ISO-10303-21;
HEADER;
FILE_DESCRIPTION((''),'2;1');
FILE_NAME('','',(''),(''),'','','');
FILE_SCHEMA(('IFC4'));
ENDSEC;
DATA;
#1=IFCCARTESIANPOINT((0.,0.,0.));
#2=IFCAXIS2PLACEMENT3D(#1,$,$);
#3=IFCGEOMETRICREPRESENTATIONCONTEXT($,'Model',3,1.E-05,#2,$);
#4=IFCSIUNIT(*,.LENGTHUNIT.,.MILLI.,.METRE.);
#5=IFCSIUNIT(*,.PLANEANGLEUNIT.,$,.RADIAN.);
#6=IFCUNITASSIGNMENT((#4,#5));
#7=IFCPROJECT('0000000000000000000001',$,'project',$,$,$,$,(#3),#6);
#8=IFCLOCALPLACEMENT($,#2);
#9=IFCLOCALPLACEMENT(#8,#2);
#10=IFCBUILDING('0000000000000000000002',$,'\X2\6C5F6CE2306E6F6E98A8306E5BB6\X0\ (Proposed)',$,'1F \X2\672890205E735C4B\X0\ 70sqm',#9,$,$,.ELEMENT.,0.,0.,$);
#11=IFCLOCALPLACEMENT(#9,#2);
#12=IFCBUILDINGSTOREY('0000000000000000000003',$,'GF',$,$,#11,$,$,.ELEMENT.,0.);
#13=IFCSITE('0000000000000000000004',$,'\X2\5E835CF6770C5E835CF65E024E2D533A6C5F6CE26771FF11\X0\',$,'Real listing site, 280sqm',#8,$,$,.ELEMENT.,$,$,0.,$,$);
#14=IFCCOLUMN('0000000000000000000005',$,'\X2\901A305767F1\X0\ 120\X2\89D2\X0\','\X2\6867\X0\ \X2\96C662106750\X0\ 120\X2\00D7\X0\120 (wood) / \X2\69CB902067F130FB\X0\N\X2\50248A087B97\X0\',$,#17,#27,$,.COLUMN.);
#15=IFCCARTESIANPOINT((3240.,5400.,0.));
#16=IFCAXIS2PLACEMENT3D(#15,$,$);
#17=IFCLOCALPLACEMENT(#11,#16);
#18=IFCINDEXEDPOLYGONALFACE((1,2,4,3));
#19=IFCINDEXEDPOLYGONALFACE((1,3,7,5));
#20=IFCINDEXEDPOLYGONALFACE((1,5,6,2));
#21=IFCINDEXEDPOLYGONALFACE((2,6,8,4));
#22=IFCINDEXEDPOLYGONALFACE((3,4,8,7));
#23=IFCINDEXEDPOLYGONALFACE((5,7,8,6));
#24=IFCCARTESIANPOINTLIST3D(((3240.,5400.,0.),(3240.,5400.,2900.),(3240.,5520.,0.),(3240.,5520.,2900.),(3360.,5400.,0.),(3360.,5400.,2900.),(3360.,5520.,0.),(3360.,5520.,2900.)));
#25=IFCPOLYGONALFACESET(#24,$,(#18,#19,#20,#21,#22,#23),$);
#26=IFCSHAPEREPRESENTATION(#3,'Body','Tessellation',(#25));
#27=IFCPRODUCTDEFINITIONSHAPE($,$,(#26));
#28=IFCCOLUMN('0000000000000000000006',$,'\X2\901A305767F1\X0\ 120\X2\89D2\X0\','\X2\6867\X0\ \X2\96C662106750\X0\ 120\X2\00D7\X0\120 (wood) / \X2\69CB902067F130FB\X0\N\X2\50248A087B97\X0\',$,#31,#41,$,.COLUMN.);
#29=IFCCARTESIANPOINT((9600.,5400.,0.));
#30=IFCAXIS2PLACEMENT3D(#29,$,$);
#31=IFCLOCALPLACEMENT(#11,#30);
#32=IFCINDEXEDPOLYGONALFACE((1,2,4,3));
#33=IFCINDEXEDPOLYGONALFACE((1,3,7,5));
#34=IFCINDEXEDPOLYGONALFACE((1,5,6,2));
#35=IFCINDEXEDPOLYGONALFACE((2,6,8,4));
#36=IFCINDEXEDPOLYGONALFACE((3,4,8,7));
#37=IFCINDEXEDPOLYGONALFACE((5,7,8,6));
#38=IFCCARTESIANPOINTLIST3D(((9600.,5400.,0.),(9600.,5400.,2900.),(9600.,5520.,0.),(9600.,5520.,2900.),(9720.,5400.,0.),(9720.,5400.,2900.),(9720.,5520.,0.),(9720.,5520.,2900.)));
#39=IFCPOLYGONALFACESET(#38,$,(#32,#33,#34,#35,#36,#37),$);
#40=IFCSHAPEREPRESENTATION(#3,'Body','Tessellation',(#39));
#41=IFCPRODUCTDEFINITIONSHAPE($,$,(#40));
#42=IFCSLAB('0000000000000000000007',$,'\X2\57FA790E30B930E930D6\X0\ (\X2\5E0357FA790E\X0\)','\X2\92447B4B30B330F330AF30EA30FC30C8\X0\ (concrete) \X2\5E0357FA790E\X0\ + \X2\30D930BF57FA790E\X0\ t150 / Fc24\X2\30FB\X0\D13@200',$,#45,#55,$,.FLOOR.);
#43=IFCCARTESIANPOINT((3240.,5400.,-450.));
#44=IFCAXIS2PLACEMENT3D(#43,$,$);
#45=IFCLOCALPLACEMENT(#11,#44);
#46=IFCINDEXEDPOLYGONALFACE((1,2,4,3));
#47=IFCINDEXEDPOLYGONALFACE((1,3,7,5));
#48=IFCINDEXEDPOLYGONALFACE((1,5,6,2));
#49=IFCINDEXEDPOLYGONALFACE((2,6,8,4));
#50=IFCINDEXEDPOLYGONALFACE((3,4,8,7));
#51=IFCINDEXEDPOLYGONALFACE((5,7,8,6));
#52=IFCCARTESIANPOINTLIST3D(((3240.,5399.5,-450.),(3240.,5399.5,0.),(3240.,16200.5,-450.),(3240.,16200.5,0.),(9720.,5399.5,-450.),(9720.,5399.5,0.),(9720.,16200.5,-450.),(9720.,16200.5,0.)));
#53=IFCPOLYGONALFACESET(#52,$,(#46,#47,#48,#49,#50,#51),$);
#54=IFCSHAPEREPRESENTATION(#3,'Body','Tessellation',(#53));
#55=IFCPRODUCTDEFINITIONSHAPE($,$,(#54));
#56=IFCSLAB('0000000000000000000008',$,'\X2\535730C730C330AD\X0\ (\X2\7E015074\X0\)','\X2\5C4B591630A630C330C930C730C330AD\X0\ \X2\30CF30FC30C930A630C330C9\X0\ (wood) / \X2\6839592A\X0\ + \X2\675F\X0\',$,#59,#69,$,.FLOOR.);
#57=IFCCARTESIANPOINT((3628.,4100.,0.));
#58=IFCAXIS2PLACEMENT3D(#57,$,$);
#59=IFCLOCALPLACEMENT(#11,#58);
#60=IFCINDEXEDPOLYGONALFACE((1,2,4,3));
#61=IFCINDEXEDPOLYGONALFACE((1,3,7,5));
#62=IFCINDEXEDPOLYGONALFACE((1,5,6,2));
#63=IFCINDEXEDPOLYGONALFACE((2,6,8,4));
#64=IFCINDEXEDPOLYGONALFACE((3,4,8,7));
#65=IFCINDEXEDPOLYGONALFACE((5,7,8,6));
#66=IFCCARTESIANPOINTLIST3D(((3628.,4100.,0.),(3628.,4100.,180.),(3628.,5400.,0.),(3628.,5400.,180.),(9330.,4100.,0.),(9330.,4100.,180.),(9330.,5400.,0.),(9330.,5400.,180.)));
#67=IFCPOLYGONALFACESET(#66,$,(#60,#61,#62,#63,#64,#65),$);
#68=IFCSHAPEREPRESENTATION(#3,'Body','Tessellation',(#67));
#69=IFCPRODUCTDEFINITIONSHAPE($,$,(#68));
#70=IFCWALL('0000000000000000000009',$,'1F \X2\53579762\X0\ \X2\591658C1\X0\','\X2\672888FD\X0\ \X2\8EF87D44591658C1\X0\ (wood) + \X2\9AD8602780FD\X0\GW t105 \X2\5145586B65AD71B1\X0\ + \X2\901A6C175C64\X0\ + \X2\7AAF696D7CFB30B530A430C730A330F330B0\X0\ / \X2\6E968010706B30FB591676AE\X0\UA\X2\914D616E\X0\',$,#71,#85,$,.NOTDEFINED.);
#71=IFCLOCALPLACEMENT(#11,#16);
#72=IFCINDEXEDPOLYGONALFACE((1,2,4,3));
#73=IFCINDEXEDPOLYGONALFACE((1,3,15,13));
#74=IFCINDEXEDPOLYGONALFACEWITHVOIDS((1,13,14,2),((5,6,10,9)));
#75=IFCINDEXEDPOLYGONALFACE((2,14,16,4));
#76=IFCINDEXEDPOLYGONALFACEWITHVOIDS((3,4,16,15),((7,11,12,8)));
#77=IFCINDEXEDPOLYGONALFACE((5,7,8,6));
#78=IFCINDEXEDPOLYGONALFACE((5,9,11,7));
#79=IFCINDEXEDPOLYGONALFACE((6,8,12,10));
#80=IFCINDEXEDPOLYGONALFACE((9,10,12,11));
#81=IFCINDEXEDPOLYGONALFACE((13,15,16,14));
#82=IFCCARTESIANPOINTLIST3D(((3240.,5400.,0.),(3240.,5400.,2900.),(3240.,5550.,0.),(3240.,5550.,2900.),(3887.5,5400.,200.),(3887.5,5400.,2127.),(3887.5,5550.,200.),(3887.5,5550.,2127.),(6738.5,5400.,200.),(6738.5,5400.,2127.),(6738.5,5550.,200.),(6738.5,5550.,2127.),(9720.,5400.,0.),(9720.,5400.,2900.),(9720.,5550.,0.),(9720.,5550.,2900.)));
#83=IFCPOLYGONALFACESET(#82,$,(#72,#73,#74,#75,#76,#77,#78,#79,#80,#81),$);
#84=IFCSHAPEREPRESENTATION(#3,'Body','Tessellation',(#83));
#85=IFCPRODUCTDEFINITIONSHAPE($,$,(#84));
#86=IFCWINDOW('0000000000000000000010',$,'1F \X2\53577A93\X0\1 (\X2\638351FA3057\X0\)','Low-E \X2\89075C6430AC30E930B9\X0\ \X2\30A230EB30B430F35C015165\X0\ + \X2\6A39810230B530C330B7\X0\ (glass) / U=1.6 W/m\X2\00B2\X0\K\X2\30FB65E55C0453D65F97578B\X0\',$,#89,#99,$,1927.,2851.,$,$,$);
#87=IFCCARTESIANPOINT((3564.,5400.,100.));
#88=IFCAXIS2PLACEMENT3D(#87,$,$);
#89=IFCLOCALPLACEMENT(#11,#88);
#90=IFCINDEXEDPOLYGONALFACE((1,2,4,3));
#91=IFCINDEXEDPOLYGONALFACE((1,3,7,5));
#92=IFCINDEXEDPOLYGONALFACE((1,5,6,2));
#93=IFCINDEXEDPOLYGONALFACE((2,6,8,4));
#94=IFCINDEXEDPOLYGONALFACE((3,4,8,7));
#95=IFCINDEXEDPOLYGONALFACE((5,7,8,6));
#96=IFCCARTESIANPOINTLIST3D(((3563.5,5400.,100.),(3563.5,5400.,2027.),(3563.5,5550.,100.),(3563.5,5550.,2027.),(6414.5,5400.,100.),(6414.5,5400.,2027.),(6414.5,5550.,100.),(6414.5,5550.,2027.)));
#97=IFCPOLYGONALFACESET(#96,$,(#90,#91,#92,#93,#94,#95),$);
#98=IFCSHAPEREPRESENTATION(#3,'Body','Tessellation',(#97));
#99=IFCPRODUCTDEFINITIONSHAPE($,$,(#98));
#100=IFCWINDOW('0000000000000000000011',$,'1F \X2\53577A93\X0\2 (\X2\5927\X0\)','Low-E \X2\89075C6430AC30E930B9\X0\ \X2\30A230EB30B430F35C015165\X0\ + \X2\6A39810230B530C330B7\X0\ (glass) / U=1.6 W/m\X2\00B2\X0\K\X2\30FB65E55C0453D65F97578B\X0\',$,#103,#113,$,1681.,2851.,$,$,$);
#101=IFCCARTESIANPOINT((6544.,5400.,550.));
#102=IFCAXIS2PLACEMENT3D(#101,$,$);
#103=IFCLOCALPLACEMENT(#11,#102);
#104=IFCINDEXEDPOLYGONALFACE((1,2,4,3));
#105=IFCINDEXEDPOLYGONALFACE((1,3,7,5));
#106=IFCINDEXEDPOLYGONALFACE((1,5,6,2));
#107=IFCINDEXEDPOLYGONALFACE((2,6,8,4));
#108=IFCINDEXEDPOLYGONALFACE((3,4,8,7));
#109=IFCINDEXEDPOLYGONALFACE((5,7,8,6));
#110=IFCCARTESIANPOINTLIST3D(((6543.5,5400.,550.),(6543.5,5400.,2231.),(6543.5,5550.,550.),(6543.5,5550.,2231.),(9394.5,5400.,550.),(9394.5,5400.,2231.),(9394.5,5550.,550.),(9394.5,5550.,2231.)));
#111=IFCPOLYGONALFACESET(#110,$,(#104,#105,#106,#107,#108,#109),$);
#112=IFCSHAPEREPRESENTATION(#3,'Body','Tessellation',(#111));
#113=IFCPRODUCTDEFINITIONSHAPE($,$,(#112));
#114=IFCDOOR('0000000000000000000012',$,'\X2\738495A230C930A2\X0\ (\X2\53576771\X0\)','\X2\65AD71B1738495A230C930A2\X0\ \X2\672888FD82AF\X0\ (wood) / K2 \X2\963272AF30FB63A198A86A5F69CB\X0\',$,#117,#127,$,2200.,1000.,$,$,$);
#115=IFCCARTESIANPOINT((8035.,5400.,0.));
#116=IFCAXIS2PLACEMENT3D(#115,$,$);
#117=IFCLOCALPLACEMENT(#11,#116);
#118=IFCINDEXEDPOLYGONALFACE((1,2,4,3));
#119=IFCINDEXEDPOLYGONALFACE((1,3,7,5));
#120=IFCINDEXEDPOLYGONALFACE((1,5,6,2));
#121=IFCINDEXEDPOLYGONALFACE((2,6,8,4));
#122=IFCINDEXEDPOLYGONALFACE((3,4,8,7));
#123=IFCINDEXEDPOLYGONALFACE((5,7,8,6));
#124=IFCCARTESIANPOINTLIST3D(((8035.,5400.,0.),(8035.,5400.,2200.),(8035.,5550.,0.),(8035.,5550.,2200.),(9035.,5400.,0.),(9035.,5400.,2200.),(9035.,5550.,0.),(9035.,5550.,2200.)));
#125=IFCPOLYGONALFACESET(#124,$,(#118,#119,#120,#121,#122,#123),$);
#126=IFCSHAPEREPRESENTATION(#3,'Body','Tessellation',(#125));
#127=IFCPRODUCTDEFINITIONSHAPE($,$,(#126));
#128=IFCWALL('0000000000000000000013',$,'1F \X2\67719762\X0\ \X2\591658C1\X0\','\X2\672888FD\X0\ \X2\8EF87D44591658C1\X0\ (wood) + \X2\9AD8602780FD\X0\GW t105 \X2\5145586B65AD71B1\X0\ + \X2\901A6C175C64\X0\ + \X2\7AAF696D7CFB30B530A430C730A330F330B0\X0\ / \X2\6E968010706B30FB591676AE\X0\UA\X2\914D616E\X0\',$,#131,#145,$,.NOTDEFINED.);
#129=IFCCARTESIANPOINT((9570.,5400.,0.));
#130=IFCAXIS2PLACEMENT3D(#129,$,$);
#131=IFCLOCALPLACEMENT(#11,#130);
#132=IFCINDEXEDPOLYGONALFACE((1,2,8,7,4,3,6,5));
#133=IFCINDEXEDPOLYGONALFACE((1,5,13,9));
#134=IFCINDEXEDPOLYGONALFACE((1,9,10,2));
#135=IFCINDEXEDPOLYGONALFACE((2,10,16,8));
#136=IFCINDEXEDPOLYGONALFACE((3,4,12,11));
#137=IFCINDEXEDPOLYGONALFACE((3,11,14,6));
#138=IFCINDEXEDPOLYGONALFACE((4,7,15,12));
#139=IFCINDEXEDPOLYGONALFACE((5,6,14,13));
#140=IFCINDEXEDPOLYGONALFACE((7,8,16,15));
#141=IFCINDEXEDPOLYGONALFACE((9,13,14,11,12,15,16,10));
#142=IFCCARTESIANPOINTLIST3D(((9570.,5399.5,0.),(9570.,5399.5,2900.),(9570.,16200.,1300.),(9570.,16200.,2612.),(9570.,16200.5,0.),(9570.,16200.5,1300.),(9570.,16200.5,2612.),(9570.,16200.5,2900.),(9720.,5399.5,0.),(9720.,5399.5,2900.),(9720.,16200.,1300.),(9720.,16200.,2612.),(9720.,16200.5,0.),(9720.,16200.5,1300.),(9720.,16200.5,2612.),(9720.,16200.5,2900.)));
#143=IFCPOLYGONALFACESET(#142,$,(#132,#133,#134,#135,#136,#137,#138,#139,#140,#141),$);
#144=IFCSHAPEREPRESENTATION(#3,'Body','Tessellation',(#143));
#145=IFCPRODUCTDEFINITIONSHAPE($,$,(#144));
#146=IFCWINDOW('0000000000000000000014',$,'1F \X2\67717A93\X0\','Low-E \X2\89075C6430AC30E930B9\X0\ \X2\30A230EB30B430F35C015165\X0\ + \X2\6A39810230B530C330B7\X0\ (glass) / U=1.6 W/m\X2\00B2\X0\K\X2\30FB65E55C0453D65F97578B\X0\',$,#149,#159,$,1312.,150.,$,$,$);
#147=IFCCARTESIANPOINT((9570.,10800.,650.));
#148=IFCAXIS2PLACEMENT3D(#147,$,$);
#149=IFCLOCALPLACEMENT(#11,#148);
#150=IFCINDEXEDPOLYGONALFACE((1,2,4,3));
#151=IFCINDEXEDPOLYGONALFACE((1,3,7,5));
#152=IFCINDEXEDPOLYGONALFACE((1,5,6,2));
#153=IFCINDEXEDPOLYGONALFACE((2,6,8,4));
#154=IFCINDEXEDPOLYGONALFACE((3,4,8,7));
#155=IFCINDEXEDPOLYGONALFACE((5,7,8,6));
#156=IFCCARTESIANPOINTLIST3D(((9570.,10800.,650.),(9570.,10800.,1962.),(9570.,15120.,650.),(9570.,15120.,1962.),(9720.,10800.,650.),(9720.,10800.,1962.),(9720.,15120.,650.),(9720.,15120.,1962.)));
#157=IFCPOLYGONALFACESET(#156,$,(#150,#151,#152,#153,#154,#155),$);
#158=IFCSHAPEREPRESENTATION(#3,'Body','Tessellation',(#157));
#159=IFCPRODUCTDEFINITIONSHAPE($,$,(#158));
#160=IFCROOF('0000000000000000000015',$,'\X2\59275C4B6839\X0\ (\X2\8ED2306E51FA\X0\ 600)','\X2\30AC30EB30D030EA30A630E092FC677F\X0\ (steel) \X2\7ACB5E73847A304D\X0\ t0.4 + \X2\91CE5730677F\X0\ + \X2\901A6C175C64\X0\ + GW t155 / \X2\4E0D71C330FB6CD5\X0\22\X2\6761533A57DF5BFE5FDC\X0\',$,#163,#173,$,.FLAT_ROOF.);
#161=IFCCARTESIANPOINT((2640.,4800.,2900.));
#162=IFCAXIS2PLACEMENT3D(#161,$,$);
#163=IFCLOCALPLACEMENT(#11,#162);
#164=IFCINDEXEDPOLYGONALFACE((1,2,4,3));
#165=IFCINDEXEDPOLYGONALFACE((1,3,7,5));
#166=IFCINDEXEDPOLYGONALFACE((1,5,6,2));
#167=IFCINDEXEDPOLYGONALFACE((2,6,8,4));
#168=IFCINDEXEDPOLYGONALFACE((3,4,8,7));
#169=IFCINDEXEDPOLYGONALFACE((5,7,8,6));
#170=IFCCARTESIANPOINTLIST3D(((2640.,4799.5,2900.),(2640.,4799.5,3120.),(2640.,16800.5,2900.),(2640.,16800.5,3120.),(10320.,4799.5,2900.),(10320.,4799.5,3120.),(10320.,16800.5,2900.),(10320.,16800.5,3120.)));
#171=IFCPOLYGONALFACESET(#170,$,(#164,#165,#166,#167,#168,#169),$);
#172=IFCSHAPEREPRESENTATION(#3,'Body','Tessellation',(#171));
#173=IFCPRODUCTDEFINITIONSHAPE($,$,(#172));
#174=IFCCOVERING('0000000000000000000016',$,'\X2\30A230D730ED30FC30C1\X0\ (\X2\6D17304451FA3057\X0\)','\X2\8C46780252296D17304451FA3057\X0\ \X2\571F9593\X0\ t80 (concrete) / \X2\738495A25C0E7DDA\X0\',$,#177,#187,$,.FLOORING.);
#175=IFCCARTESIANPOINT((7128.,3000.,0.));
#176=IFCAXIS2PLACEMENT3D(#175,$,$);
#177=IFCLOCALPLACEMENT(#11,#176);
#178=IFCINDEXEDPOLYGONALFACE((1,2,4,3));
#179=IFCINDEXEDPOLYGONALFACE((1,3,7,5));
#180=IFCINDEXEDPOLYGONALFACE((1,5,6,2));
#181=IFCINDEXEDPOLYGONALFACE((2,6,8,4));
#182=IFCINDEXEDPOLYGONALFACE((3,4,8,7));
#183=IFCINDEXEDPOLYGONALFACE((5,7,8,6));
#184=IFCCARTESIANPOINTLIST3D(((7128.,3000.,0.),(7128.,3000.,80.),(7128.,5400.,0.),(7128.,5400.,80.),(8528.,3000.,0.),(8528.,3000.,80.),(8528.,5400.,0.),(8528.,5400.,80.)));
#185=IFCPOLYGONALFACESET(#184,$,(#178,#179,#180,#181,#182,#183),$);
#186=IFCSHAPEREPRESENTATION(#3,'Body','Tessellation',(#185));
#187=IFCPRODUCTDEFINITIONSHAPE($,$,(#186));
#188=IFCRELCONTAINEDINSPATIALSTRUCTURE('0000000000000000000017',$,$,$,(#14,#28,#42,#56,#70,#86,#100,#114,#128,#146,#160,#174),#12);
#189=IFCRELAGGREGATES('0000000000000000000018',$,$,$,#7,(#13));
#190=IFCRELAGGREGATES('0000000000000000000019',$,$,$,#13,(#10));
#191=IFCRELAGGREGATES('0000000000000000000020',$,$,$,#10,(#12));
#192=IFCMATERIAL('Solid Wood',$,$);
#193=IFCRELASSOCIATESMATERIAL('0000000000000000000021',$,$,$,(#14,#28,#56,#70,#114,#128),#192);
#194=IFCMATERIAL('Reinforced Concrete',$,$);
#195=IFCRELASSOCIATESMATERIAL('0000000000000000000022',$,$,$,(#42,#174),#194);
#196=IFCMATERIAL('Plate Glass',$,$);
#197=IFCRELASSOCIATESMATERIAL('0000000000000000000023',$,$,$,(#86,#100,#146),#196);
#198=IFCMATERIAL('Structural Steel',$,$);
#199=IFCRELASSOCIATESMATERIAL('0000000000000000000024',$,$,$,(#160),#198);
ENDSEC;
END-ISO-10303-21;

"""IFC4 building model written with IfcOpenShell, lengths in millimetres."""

from ifc_helpers import new_model, si_unit, frame, frame_2d, origin, place, context, project, spatial, rectangle, extrude, material, element, fill, save


model = new_model("IFC4")

# Units and contexts
model_context = context("Model", 3, precision=1e-05, world=origin())
ifc_project = project(units=[si_unit("LENGTHUNIT", "METRE", prefix="MILLI"), si_unit("PLANEANGLEUNIT", "RADIAN")], contexts=[model_context])

# Site, building, storey
site_placement = place(None, origin())
site = spatial("IfcSite", under=ifc_project, at=site_placement, Name="広島県広島市中区江波東１", ObjectType="Real listing site, 280sqm", CompositionType="ELEMENT", RefElevation=0.0)
building_placement = place(site_placement, origin())
building = spatial("IfcBuilding", under=site, at=building_placement, Name="江波の潮風の家 (Proposed)", ObjectType="1F 木造平屋 70sqm", CompositionType="ELEMENT", ElevationOfRefHeight=0.0, ElevationOfTerrain=0.0)
storey_placement = place(building_placement, origin())
storey = spatial("IfcBuildingStorey", under=building, at=storey_placement, Name="GF", CompositionType="ELEMENT", Elevation=0.0)

# Columns
ifc_material_1 = material(Name="Solid Wood")
column_1_placement = place(storey_placement, frame((3240.0, 5400.0, 0.0)))
element("IfcColumn", 1, at=column_1_placement, inside=storey, material=ifc_material_1, Name="通し柱 120角", Description="桧 集成材 120×120 (wood) / 構造柱・N値計算", PredefinedType="COLUMN", context=model_context, shape_type="SweptSolid", body=[
    extrude(rectangle(XDim=120.0, YDim=120.0, at=frame_2d((60.0, 60.0))), frame((3240.0, 5400.0, 0.0)), (0.0, 0.0, 1.0), 2900.0),
])
column_2_placement = place(storey_placement, frame((9600.0, 5400.0, 0.0)))
element("IfcColumn", 2, at=column_2_placement, inside=storey, material=ifc_material_1, Name="通し柱 120角", Description="桧 集成材 120×120 (wood) / 構造柱・N値計算", PredefinedType="COLUMN", context=model_context, shape_type="SweptSolid", body=[
    extrude(rectangle(XDim=120.0, YDim=120.0, at=frame_2d((60.0, 60.0))), frame((9600.0, 5400.0, 0.0)), (0.0, 0.0, 1.0), 2900.0),
])

# Slabs
ifc_material_2 = material(Name="Reinforced Concrete")
slab_1_placement = place(storey_placement, frame((3240.0, 5400.0, -450.0)))
element("IfcSlab", 3, at=slab_1_placement, inside=storey, material=ifc_material_2, Name="基礎スラブ (布基礎)", Description="鉄筋コンクリート (concrete) 布基礎 + ベタ基礎 t150 / Fc24・D13@200", PredefinedType="FLOOR", context=model_context, shape_type="SweptSolid", body=[
    extrude(rectangle(XDim=6480.0, YDim=10801.0, at=frame_2d((3240.0, 5400.0))), frame((3240.0, 5400.0, -450.0)), (0.0, 0.0, 1.0), 450.0),
])
slab_2_placement = place(storey_placement, frame((3628.0, 4100.0, 0.0)))
element("IfcSlab", 4, at=slab_2_placement, inside=storey, material=ifc_material_1, Name="南デッキ (縁側)", Description="屋外ウッドデッキ ハードウッド (wood) / 根太 + 束", PredefinedType="FLOOR", context=model_context, shape_type="SweptSolid", body=[
    extrude(rectangle(XDim=5702.0, YDim=1300.0, at=frame_2d((2851.0, 650.0))), frame((3628.0, 4100.0, 0.0)), (0.0, 0.0, 1.0), 180.0),
])

# Wall, openings, windows, door
wall_1_placement = place(storey_placement, frame((3240.0, 5400.0, 0.0)))
wall_1 = element("IfcWall", 5, at=wall_1_placement, inside=storey, material=ifc_material_1, Name="1F 南面 外壁", Description="木製 軸組外壁 (wood) + 高性能GW t105 充填断熱 + 通気層 + 窯業系サイディング / 準耐火・外皮UA配慮", PredefinedType="NOTDEFINED", context=model_context, shape_type="SweptSolid", body=[
    extrude(rectangle(XDim=6480.0, YDim=150.0, at=frame_2d((3240.0, 75.0))), frame((3240.0, 5400.0, 0.0)), (0.0, 0.0, 1.0), 2900.0),
])
opening_1_placement = place(storey_placement, frame((3564.0, 5400.0, 100.0)))
opening_1 = element("IfcOpeningElement", 6, at=opening_1_placement, cuts=wall_1, PredefinedType="NOTDEFINED", context=model_context, shape_type="SweptSolid", body=[
    extrude(rectangle(XDim=2851.0, YDim=150.0, at=frame_2d((1425.0, 75.0))), frame((3564.0, 5400.0, 100.0)), (0.0, 0.0, 1.0), 1927.0),
])
opening_2_placement = place(storey_placement, frame((6544.0, 5400.0, 550.0)))
opening_2 = element("IfcOpeningElement", 7, at=opening_2_placement, cuts=wall_1, PredefinedType="NOTDEFINED", context=model_context, shape_type="SweptSolid", body=[
    extrude(rectangle(XDim=2851.0, YDim=150.0, at=frame_2d((1425.0, 75.0))), frame((6544.0, 5400.0, 550.0)), (0.0, 0.0, 1.0), 1681.0),
])
opening_3_placement = place(storey_placement, frame((8035.0, 5400.0, 0.0)))
opening_3 = element("IfcOpeningElement", 8, at=opening_3_placement, cuts=wall_1, PredefinedType="NOTDEFINED", context=model_context, shape_type="SweptSolid", body=[
    extrude(rectangle(XDim=1000.0, YDim=150.0, at=frame_2d((500.0, 75.0))), frame((8035.0, 5400.0, 0.0)), (0.0, 0.0, 1.0), 2200.0),
])
ifc_material_3 = material(Name="Plate Glass")
window_1_placement = place(storey_placement, frame((3564.0, 5400.0, 100.0)))
window_1 = element("IfcWindow", 9, at=window_1_placement, inside=storey, material=ifc_material_3, Name="1F 南窓1 (掃出し)", Description="Low-E 複層ガラス アルゴン封入 + 樹脂サッシ (glass) / U=1.6 W/m²K・日射取得型", OverallHeight=1927.0, OverallWidth=2851.0, context=model_context, shape_type="SweptSolid", body=[
    extrude(rectangle(XDim=2851.0, YDim=150.0, at=frame_2d((1425.0, 75.0))), frame((3564.0, 5400.0, 100.0)), (0.0, 0.0, 1.0), 1927.0),
])
fill(opening_1, window_1)
window_2_placement = place(storey_placement, frame((6544.0, 5400.0, 550.0)))
window_2 = element("IfcWindow", 10, at=window_2_placement, inside=storey, material=ifc_material_3, Name="1F 南窓2 (大)", Description="Low-E 複層ガラス アルゴン封入 + 樹脂サッシ (glass) / U=1.6 W/m²K・日射取得型", OverallHeight=1681.0, OverallWidth=2851.0, context=model_context, shape_type="SweptSolid", body=[
    extrude(rectangle(XDim=2851.0, YDim=150.0, at=frame_2d((1425.0, 75.0))), frame((6544.0, 5400.0, 550.0)), (0.0, 0.0, 1.0), 1681.0),
])
fill(opening_2, window_2)
door_placement = place(storey_placement, frame((8035.0, 5400.0, 0.0)))
door = element("IfcDoor", 11, at=door_placement, inside=storey, material=ifc_material_1, Name="玄関ドア (南東)", Description="断熱玄関ドア 木製芯 (wood) / K2 防犯・採風機構", OverallHeight=2200.0, OverallWidth=1000.0, context=model_context, shape_type="SweptSolid", body=[
    extrude(rectangle(XDim=1000.0, YDim=150.0, at=frame_2d((500.0, 75.0))), frame((8035.0, 5400.0, 0.0)), (0.0, 0.0, 1.0), 2200.0),
])
fill(opening_3, door)

# Wall, opening, window
wall_2_placement = place(storey_placement, frame((9570.0, 5400.0, 0.0)))
wall_2 = element("IfcWall", 12, at=wall_2_placement, inside=storey, material=ifc_material_1, Name="1F 東面 外壁", Description="木製 軸組外壁 (wood) + 高性能GW t105 充填断熱 + 通気層 + 窯業系サイディング / 準耐火・外皮UA配慮", PredefinedType="NOTDEFINED", context=model_context, shape_type="SweptSolid", body=[
    extrude(rectangle(XDim=150.0, YDim=10801.0, at=frame_2d((75.0, 5400.0))), frame((9570.0, 5400.0, 0.0)), (0.0, 0.0, 1.0), 2900.0),
])
opening_4_placement = place(storey_placement, frame((9570.0, 10800.0, 650.0)))
opening_4 = element("IfcOpeningElement", 13, at=opening_4_placement, cuts=wall_2, PredefinedType="NOTDEFINED", context=model_context, shape_type="SweptSolid", body=[
    extrude(rectangle(XDim=150.0, YDim=4320.0, at=frame_2d((75.0, 2160.0))), frame((9570.0, 10800.0, 650.0)), (0.0, 0.0, 1.0), 1312.0),
])
window_3_placement = place(storey_placement, frame((9570.0, 10800.0, 650.0)))
window_3 = element("IfcWindow", 14, at=window_3_placement, inside=storey, material=ifc_material_3, Name="1F 東窓", Description="Low-E 複層ガラス アルゴン封入 + 樹脂サッシ (glass) / U=1.6 W/m²K・日射取得型", OverallHeight=1312.0, OverallWidth=150.0, context=model_context, shape_type="SweptSolid", body=[
    extrude(rectangle(XDim=150.0, YDim=4320.0, at=frame_2d((75.0, 2160.0))), frame((9570.0, 10800.0, 650.0)), (0.0, 0.0, 1.0), 1312.0),
])
fill(opening_4, window_3)

# Roof
ifc_material_4 = material(Name="Structural Steel")
roof_placement = place(storey_placement, frame((2640.0, 4800.0, 2900.0)))
element("IfcRoof", 15, at=roof_placement, inside=storey, material=ifc_material_4, Name="大屋根 (軒の出 600)", Description="ガルバリウム鋼板 (steel) 立平葺き t0.4 + 野地板 + 通気層 + GW t155 / 不燃・法22条区域対応", PredefinedType="FLAT_ROOF", context=model_context, shape_type="SweptSolid", body=[
    extrude(rectangle(XDim=7680.0, YDim=12001.0, at=frame_2d((3840.0, 6000.0))), frame((2640.0, 4800.0, 2900.0)), (0.0, 0.0, 1.0), 220.0),
])

# Covering
covering_1_placement = place(storey_placement, frame((7128.0, 3000.0, 0.0)))
element("IfcCovering", 16, at=covering_1_placement, inside=storey, material=ifc_material_2, Name="アプローチ (洗い出し)", Description="豆砂利洗い出し 土間 t80 (concrete) / 玄関導線", PredefinedType="FLOORING", context=model_context, shape_type="SweptSolid", body=[
    extrude(rectangle(XDim=1400.0, YDim=2400.0, at=frame_2d((700.0, 1200.0))), frame((7128.0, 3000.0, 0.0)), (0.0, 0.0, 1.0), 80.0),
])

save(model, "model.ifc")
